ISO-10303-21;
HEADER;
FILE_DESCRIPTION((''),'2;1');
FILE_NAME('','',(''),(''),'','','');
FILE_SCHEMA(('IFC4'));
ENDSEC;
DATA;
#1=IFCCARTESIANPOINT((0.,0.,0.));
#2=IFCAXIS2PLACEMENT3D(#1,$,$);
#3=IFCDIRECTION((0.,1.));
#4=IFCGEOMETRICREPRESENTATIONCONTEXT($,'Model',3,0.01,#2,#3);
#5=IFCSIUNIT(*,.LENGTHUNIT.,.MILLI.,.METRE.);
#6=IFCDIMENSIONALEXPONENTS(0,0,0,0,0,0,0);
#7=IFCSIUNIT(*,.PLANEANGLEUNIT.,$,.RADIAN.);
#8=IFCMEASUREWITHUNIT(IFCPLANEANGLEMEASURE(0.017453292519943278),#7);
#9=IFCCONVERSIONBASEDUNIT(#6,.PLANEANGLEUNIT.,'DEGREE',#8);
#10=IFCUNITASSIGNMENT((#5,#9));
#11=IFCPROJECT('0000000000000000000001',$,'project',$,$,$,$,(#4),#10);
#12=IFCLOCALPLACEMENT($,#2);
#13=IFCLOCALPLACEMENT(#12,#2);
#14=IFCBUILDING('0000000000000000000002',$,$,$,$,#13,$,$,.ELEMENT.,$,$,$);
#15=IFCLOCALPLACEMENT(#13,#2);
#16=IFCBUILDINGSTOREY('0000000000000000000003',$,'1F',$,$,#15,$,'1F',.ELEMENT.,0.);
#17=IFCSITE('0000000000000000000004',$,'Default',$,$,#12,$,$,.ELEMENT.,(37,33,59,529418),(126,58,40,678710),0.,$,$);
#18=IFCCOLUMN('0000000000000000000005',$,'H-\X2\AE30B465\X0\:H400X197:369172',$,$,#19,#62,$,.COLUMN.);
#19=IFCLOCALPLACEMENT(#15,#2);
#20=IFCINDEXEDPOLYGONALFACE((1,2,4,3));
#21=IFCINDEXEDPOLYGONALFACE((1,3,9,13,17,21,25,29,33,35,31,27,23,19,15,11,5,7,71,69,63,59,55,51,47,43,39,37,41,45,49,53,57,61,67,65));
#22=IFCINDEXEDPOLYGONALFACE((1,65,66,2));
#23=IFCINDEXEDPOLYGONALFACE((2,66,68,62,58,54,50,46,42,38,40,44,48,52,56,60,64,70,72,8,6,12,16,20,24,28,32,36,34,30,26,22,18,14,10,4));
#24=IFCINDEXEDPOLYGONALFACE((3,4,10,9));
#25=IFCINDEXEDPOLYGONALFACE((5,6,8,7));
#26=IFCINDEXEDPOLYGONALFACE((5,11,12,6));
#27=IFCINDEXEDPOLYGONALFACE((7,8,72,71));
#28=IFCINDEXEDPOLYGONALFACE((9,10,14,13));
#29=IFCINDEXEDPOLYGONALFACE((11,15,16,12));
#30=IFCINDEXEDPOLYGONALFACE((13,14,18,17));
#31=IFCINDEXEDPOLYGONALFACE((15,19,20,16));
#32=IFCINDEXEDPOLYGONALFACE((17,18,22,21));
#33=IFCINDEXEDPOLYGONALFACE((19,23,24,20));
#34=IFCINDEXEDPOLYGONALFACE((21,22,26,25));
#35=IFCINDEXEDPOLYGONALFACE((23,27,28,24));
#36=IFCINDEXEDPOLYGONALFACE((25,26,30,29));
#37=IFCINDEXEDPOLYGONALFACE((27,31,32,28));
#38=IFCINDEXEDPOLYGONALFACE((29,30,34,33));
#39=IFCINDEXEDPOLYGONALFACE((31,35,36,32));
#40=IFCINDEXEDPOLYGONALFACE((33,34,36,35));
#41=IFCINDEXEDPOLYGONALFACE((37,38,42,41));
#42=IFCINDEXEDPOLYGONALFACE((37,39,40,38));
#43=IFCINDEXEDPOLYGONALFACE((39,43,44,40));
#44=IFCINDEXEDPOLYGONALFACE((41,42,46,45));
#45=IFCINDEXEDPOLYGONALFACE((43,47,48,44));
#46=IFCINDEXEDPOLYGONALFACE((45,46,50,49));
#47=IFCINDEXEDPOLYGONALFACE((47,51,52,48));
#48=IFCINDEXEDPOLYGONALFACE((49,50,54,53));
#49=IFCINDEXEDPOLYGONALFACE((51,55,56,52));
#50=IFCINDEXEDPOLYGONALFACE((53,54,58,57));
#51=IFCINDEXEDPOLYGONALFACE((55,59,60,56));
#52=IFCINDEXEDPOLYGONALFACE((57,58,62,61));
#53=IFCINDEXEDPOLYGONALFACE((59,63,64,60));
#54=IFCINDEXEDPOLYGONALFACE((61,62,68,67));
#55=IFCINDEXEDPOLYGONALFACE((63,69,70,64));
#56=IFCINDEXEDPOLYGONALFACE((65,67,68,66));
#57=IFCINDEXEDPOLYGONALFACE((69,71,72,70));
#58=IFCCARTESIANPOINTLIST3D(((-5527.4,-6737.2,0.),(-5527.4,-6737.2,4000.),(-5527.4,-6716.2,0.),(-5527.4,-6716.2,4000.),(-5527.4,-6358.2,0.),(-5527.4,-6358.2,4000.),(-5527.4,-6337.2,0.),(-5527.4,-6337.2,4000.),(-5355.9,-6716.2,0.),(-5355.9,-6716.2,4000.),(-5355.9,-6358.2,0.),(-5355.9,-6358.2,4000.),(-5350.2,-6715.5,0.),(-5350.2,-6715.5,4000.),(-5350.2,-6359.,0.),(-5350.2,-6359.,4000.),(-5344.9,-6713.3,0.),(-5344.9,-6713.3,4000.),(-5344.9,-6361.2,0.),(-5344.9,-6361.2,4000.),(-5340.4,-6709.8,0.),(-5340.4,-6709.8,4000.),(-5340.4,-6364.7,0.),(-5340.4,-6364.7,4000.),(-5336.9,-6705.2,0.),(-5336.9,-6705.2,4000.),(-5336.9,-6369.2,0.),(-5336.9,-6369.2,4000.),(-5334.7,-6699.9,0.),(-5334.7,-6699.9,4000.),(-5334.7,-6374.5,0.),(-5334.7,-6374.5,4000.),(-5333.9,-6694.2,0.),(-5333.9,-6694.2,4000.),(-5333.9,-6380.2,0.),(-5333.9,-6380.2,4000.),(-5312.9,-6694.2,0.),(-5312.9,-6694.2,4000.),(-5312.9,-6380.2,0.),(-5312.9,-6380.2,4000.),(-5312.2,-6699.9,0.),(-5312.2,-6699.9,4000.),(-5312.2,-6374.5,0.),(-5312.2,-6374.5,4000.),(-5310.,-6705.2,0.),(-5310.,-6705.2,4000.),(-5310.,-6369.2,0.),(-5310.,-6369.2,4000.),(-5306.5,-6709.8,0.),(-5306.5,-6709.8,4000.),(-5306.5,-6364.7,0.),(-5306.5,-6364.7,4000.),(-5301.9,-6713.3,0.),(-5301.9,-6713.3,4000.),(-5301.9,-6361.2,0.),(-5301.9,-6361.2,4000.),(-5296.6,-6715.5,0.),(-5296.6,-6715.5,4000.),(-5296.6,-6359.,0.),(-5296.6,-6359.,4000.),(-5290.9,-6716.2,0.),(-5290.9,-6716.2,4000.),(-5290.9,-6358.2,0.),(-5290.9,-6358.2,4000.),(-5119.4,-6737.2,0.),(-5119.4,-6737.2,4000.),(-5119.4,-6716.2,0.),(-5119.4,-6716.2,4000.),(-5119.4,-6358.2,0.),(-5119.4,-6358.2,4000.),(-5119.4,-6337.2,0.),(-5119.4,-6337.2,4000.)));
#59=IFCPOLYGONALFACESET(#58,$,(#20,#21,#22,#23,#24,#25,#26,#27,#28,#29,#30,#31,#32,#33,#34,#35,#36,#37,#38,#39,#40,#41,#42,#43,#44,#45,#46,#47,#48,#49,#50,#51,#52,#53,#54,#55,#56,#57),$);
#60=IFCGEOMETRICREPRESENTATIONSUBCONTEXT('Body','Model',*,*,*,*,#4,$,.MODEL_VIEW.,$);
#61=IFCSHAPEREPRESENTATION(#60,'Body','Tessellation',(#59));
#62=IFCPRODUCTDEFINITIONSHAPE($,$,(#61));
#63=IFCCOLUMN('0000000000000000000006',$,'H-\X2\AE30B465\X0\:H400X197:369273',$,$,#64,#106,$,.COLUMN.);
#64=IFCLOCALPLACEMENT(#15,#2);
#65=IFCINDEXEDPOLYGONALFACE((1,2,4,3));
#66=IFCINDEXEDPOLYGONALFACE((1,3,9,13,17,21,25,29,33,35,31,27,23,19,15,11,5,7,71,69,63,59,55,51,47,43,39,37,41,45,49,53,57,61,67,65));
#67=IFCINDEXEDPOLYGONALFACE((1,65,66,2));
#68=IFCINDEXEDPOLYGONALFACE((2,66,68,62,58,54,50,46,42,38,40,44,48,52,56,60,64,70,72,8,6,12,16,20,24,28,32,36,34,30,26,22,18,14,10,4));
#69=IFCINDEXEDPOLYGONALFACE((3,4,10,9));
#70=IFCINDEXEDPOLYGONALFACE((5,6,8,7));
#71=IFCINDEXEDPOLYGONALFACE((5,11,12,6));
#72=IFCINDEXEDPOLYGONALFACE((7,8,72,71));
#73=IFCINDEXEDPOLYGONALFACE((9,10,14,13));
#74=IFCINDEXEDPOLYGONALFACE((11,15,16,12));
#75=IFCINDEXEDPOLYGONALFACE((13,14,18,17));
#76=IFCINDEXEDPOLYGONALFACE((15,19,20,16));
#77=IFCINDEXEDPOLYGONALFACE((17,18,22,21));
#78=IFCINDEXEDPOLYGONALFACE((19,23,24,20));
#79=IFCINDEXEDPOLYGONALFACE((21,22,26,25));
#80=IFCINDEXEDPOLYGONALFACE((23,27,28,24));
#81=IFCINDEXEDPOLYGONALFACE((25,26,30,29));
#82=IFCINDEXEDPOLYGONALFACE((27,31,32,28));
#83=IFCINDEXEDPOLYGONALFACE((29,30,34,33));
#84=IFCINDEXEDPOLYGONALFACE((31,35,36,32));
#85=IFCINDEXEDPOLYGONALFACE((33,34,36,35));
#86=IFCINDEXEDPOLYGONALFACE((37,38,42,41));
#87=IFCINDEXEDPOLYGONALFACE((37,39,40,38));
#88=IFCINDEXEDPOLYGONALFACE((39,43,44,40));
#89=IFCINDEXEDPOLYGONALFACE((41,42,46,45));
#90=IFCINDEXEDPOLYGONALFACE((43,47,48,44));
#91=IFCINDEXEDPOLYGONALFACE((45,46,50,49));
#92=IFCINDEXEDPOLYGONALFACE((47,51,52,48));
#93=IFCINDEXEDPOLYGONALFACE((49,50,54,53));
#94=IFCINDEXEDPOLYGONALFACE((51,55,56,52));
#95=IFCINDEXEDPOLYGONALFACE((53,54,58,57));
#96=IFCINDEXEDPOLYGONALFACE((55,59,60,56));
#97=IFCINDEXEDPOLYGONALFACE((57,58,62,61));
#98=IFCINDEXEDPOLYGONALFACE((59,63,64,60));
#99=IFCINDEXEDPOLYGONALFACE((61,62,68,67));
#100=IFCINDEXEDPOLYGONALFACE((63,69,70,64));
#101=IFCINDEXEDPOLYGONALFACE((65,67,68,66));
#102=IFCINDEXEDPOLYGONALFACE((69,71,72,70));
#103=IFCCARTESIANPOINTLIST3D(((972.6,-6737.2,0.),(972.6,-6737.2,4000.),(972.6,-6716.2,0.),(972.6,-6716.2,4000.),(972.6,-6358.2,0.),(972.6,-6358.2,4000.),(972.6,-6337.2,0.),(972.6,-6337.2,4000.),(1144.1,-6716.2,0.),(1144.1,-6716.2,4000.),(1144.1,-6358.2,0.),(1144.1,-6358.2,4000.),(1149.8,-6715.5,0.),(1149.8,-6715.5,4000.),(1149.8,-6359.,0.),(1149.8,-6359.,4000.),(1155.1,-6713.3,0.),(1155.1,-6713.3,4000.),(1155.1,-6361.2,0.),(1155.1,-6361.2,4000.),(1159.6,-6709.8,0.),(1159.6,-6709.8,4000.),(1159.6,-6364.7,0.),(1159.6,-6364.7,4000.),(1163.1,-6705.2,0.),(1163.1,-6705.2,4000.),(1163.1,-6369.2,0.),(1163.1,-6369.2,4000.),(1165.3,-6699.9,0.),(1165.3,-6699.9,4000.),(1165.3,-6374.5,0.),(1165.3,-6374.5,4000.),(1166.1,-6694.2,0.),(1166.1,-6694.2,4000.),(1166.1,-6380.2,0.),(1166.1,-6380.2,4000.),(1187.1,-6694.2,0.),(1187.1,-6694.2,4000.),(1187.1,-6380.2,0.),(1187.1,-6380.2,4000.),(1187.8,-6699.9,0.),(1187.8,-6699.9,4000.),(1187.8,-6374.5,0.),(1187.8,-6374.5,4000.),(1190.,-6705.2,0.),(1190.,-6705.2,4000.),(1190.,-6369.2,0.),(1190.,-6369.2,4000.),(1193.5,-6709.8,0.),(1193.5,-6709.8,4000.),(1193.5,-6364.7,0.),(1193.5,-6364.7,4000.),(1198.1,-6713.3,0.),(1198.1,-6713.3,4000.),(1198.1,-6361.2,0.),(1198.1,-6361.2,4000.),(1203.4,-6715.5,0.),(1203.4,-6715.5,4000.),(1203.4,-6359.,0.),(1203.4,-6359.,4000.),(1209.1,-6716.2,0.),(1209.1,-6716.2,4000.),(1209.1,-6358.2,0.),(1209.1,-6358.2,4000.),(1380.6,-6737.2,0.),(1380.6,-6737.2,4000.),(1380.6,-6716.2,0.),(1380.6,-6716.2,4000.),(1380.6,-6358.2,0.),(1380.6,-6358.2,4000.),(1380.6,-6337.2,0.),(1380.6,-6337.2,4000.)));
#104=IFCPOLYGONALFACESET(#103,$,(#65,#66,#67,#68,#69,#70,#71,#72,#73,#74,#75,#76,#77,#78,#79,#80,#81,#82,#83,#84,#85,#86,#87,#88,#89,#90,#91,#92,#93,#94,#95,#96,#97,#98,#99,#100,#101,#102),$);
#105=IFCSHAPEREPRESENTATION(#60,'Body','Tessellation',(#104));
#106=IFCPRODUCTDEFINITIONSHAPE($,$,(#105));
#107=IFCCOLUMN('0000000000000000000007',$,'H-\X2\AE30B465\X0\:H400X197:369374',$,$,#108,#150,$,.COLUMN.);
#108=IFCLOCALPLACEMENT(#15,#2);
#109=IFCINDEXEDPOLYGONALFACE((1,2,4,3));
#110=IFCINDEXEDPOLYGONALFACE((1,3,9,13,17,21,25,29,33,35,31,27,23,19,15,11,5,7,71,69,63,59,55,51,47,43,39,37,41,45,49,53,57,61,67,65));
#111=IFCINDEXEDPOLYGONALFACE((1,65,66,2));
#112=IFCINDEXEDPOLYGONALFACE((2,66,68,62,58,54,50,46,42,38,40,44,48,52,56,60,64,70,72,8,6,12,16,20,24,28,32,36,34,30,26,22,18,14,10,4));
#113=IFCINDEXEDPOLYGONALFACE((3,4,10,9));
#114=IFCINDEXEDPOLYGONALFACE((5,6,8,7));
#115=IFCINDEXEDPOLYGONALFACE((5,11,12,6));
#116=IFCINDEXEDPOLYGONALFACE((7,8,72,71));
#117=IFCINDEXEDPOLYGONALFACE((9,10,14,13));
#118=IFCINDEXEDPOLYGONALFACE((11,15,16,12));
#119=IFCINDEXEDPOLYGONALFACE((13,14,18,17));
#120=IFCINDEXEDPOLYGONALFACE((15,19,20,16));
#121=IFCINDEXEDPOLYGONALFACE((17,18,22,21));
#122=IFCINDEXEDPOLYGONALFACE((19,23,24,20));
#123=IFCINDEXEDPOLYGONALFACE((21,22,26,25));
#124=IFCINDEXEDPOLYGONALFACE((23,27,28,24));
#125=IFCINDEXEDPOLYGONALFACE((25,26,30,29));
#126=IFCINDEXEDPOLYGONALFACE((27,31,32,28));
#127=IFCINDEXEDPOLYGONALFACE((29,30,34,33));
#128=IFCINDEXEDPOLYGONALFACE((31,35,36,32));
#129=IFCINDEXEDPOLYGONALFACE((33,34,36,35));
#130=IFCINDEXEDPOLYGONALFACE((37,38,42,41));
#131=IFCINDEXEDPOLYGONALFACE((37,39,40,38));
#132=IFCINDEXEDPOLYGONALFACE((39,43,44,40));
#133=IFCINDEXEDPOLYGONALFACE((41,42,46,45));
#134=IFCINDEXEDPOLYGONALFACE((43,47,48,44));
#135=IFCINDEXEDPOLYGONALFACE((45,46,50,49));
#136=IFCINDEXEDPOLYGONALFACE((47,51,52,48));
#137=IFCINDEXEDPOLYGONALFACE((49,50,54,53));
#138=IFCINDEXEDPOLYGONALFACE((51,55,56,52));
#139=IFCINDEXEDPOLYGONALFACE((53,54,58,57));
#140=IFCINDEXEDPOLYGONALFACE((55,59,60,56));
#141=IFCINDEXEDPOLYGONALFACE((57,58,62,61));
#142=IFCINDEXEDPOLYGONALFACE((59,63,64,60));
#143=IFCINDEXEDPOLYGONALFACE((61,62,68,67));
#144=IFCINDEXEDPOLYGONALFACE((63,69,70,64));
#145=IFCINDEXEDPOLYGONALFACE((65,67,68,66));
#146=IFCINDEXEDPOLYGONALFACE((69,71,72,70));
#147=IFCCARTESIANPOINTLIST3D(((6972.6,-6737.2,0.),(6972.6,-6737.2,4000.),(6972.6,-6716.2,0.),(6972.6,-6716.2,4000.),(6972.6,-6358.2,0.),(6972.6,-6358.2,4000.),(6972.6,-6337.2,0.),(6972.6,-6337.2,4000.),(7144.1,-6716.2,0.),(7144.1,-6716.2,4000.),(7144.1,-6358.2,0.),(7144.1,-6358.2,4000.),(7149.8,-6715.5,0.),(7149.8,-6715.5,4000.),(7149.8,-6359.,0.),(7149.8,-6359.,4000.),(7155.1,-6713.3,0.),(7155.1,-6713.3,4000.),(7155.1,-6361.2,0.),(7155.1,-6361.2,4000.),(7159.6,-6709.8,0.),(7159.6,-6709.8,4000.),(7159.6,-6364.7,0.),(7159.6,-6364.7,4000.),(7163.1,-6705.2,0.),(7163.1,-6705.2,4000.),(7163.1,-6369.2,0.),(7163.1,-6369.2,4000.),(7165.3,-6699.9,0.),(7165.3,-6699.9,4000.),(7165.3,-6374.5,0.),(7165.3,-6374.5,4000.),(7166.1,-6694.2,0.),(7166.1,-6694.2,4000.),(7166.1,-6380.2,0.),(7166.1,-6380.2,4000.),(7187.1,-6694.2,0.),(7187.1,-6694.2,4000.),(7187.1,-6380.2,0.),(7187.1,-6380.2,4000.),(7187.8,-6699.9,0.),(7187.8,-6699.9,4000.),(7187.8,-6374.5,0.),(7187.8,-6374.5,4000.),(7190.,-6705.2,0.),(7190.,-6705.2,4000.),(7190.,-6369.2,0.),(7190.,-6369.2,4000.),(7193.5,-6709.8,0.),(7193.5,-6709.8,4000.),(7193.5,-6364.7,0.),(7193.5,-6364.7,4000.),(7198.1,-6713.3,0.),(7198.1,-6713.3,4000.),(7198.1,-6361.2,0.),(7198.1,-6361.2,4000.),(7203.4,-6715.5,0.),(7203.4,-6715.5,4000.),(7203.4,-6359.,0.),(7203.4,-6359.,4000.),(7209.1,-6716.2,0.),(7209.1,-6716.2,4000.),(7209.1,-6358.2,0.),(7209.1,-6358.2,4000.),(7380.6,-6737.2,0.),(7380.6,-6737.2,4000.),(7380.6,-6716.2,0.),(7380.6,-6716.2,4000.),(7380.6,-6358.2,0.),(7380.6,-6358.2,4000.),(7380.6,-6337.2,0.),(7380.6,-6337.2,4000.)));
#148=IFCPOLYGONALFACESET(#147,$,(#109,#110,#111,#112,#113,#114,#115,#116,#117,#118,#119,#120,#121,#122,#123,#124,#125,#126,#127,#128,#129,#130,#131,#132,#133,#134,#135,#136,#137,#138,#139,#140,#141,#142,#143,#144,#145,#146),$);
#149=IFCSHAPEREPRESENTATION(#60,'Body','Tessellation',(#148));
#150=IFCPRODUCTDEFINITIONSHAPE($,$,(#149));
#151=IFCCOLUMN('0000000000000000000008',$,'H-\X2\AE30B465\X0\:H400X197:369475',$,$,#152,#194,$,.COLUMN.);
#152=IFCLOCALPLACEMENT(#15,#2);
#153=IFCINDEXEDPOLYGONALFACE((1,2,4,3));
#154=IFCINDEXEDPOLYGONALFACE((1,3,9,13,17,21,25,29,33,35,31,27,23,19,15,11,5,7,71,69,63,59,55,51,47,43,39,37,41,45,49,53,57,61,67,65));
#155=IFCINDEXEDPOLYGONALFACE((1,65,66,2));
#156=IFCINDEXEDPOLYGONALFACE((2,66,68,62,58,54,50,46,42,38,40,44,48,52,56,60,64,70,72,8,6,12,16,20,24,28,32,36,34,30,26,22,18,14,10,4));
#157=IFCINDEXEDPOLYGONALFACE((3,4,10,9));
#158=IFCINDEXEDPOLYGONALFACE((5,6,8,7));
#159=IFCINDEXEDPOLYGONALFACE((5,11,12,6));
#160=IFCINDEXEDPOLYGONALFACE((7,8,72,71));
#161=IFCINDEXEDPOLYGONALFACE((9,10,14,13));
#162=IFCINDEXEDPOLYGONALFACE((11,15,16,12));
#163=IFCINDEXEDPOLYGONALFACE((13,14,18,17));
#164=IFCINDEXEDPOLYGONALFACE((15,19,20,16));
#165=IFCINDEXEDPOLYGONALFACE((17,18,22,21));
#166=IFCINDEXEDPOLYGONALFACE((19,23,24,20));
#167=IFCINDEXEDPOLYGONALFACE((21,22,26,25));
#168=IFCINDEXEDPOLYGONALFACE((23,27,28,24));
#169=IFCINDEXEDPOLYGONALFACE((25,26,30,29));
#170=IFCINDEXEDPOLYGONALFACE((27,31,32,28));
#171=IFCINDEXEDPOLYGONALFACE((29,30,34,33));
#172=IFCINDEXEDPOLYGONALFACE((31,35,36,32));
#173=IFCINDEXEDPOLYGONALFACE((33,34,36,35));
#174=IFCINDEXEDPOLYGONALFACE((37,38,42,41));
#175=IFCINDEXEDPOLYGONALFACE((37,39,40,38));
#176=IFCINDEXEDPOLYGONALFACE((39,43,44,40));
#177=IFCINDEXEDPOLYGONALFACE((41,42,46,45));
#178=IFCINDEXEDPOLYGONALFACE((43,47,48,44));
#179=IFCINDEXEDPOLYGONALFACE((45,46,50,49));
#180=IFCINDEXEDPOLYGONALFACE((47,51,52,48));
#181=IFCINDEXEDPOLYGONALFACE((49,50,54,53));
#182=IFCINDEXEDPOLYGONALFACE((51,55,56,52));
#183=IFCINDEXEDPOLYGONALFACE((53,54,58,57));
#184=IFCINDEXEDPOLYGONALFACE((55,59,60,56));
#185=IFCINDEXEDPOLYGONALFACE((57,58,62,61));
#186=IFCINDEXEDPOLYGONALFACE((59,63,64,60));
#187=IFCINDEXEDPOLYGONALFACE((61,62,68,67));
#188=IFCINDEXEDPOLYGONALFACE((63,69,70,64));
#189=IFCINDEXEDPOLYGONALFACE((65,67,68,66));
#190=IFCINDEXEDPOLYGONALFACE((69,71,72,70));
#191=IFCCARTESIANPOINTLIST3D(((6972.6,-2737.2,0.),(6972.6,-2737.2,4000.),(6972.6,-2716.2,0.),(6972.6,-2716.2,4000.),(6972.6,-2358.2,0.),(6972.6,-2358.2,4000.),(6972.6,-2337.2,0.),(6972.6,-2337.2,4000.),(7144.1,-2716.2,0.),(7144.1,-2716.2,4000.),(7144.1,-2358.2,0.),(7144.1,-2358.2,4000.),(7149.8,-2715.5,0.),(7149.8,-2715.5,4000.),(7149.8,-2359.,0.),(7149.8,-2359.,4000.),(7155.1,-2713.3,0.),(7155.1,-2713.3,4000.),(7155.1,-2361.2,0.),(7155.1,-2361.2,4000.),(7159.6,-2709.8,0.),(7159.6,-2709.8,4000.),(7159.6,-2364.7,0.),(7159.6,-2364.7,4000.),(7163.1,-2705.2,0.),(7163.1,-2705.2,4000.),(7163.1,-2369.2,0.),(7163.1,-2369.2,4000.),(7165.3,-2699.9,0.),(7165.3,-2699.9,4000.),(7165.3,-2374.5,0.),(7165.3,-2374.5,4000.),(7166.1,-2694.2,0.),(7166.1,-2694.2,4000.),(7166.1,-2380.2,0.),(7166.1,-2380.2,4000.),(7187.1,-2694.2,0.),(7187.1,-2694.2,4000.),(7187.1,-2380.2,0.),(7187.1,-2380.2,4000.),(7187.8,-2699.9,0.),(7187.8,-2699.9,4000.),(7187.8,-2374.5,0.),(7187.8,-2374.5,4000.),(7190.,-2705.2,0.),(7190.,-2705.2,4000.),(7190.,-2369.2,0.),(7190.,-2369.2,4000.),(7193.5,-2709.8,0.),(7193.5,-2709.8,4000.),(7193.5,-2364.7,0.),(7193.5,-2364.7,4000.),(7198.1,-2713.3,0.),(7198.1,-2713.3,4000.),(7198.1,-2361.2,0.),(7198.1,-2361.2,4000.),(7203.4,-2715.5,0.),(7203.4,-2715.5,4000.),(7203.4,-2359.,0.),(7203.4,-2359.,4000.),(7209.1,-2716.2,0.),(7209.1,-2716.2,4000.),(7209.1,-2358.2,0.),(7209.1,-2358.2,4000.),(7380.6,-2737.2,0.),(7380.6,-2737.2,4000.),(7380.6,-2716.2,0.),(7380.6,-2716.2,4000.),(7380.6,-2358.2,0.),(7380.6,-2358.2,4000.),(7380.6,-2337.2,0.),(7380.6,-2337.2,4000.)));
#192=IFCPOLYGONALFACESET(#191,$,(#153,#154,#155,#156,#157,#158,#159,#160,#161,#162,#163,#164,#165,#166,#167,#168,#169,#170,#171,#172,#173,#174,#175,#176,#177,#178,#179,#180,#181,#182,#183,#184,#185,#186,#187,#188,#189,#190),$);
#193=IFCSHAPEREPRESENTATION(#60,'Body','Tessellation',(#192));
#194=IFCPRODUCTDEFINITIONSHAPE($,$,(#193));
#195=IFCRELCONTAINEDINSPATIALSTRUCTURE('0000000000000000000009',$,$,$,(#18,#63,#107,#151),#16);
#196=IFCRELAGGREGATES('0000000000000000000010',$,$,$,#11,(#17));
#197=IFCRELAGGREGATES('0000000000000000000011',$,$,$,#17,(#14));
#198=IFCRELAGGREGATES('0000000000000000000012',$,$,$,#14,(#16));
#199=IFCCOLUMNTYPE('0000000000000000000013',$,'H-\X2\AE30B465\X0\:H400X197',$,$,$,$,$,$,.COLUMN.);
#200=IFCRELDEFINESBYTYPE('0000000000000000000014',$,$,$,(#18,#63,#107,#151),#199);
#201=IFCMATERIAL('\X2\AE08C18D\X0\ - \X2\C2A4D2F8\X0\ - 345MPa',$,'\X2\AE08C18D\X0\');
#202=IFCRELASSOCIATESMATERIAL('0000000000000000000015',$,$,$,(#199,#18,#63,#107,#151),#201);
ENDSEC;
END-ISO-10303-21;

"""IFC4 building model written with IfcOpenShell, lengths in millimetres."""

from ifc_helpers import new_model, entity, si_unit, converted_unit, direction, frame, origin, place, context, subcontext, project, spatial, line, arc, indexed_curve, outline, extrude, source, transform, mapped, material, type_object, type_shapes, element, save


model = new_model("IFC4")

# Units and contexts
model_context = context("Model", 3, precision=0.01, world=origin(), true_north=direction((0.0, 1.0)))
body_context = subcontext(model_context, "Body", "Model", "MODEL_VIEW")
ifc_project = project(units=[si_unit("LENGTHUNIT", "METRE", prefix="MILLI"), converted_unit("PLANEANGLEUNIT", "DEGREE", entity("IfcPlaneAngleMeasure", 0.017453292519943278), si_unit("PLANEANGLEUNIT", "RADIAN"), dimensions=[0, 0, 0, 0, 0, 0, 0])], contexts=[model_context])

# Site, building, storey
site_placement = place(None, origin())
site = spatial("IfcSite", under=ifc_project, at=site_placement, Name="Default", CompositionType="ELEMENT", RefLatitude=(37, 33, 59, 529418), RefLongitude=(126, 58, 40, 678710), RefElevation=0.0)
building_placement = place(site_placement, origin())
building = spatial("IfcBuilding", under=site, at=building_placement, CompositionType="ELEMENT")
storey_placement = place(building_placement, origin())
storey = spatial("IfcBuildingStorey", under=building, at=storey_placement, Name="1F", LongName="1F", CompositionType="ELEMENT", Elevation=0.0)

# Columns
ifc_material = material(Name="금속 - 스틸 - 345MPa", Category="금속")
column_type = type_object("IfcColumnType", Name="H-기둥:H400X197", PredefinedType="COLUMN", material=ifc_material)
shared_shape = source(origin(), body_context, "Body", "SweptSolid", [
    extrude(outline(indexed_curve([(-204.0, -200.0), (204.0, -200.0), (204.0, -179.0), (32.5, -179.0), (16.9, -172.6), (10.5, -157.0), (10.5, 157.0), (16.9, 172.6), (32.5, 179.0), (204.0, 179.0), (204.0, 200.0), (-204.0, 200.0), (-204.0, 179.0), (-32.5, 179.0), (-16.9, 172.6), (-10.5, 157.0), (-10.5, -157.0), (-16.9, -172.6), (-32.5, -179.0), (-204.0, -179.0)], segments=[line(1, 2, 3, 4), arc(4, 5, 6), line(6, 7), arc(7, 8, 9), line(9, 10, 11, 12, 13, 14), arc(14, 15, 16), line(16, 17), arc(17, 18, 19), line(19, 20, 1)], self_intersect=False)), frame((0.0, 0.0, 0.0), z_axis=(0.0, 0.0, 1.0), x_axis=(-1.0, 0.0, 0.0)), (0.0, 0.0, 1.0), 4000.0),
])
type_shapes(column_type, [shared_shape])
for number, where, name in (
    (1, (-5323.4, -6537.2, 0.0), "H-기둥:H400X197:369172"),
    (2, (1176.6, -6537.2, 0.0), "H-기둥:H400X197:369273"),
    (3, (7176.6, -6537.2, 0.0), "H-기둥:H400X197:369374"),
    (4, (7176.6, -2537.2, 0.0), "H-기둥:H400X197:369475"),
):
    element("IfcColumn", number, at=place(storey_placement, frame(where)), inside=storey, type_object=column_type, material=ifc_material, Name=name, PredefinedType="COLUMN", context=body_context, shape_type="MappedRepresentation", body=[
        mapped(shared_shape, transform((0.0, 0.0, 0.0), scale=1.0)),
    ])

save(model, "model.ifc")
